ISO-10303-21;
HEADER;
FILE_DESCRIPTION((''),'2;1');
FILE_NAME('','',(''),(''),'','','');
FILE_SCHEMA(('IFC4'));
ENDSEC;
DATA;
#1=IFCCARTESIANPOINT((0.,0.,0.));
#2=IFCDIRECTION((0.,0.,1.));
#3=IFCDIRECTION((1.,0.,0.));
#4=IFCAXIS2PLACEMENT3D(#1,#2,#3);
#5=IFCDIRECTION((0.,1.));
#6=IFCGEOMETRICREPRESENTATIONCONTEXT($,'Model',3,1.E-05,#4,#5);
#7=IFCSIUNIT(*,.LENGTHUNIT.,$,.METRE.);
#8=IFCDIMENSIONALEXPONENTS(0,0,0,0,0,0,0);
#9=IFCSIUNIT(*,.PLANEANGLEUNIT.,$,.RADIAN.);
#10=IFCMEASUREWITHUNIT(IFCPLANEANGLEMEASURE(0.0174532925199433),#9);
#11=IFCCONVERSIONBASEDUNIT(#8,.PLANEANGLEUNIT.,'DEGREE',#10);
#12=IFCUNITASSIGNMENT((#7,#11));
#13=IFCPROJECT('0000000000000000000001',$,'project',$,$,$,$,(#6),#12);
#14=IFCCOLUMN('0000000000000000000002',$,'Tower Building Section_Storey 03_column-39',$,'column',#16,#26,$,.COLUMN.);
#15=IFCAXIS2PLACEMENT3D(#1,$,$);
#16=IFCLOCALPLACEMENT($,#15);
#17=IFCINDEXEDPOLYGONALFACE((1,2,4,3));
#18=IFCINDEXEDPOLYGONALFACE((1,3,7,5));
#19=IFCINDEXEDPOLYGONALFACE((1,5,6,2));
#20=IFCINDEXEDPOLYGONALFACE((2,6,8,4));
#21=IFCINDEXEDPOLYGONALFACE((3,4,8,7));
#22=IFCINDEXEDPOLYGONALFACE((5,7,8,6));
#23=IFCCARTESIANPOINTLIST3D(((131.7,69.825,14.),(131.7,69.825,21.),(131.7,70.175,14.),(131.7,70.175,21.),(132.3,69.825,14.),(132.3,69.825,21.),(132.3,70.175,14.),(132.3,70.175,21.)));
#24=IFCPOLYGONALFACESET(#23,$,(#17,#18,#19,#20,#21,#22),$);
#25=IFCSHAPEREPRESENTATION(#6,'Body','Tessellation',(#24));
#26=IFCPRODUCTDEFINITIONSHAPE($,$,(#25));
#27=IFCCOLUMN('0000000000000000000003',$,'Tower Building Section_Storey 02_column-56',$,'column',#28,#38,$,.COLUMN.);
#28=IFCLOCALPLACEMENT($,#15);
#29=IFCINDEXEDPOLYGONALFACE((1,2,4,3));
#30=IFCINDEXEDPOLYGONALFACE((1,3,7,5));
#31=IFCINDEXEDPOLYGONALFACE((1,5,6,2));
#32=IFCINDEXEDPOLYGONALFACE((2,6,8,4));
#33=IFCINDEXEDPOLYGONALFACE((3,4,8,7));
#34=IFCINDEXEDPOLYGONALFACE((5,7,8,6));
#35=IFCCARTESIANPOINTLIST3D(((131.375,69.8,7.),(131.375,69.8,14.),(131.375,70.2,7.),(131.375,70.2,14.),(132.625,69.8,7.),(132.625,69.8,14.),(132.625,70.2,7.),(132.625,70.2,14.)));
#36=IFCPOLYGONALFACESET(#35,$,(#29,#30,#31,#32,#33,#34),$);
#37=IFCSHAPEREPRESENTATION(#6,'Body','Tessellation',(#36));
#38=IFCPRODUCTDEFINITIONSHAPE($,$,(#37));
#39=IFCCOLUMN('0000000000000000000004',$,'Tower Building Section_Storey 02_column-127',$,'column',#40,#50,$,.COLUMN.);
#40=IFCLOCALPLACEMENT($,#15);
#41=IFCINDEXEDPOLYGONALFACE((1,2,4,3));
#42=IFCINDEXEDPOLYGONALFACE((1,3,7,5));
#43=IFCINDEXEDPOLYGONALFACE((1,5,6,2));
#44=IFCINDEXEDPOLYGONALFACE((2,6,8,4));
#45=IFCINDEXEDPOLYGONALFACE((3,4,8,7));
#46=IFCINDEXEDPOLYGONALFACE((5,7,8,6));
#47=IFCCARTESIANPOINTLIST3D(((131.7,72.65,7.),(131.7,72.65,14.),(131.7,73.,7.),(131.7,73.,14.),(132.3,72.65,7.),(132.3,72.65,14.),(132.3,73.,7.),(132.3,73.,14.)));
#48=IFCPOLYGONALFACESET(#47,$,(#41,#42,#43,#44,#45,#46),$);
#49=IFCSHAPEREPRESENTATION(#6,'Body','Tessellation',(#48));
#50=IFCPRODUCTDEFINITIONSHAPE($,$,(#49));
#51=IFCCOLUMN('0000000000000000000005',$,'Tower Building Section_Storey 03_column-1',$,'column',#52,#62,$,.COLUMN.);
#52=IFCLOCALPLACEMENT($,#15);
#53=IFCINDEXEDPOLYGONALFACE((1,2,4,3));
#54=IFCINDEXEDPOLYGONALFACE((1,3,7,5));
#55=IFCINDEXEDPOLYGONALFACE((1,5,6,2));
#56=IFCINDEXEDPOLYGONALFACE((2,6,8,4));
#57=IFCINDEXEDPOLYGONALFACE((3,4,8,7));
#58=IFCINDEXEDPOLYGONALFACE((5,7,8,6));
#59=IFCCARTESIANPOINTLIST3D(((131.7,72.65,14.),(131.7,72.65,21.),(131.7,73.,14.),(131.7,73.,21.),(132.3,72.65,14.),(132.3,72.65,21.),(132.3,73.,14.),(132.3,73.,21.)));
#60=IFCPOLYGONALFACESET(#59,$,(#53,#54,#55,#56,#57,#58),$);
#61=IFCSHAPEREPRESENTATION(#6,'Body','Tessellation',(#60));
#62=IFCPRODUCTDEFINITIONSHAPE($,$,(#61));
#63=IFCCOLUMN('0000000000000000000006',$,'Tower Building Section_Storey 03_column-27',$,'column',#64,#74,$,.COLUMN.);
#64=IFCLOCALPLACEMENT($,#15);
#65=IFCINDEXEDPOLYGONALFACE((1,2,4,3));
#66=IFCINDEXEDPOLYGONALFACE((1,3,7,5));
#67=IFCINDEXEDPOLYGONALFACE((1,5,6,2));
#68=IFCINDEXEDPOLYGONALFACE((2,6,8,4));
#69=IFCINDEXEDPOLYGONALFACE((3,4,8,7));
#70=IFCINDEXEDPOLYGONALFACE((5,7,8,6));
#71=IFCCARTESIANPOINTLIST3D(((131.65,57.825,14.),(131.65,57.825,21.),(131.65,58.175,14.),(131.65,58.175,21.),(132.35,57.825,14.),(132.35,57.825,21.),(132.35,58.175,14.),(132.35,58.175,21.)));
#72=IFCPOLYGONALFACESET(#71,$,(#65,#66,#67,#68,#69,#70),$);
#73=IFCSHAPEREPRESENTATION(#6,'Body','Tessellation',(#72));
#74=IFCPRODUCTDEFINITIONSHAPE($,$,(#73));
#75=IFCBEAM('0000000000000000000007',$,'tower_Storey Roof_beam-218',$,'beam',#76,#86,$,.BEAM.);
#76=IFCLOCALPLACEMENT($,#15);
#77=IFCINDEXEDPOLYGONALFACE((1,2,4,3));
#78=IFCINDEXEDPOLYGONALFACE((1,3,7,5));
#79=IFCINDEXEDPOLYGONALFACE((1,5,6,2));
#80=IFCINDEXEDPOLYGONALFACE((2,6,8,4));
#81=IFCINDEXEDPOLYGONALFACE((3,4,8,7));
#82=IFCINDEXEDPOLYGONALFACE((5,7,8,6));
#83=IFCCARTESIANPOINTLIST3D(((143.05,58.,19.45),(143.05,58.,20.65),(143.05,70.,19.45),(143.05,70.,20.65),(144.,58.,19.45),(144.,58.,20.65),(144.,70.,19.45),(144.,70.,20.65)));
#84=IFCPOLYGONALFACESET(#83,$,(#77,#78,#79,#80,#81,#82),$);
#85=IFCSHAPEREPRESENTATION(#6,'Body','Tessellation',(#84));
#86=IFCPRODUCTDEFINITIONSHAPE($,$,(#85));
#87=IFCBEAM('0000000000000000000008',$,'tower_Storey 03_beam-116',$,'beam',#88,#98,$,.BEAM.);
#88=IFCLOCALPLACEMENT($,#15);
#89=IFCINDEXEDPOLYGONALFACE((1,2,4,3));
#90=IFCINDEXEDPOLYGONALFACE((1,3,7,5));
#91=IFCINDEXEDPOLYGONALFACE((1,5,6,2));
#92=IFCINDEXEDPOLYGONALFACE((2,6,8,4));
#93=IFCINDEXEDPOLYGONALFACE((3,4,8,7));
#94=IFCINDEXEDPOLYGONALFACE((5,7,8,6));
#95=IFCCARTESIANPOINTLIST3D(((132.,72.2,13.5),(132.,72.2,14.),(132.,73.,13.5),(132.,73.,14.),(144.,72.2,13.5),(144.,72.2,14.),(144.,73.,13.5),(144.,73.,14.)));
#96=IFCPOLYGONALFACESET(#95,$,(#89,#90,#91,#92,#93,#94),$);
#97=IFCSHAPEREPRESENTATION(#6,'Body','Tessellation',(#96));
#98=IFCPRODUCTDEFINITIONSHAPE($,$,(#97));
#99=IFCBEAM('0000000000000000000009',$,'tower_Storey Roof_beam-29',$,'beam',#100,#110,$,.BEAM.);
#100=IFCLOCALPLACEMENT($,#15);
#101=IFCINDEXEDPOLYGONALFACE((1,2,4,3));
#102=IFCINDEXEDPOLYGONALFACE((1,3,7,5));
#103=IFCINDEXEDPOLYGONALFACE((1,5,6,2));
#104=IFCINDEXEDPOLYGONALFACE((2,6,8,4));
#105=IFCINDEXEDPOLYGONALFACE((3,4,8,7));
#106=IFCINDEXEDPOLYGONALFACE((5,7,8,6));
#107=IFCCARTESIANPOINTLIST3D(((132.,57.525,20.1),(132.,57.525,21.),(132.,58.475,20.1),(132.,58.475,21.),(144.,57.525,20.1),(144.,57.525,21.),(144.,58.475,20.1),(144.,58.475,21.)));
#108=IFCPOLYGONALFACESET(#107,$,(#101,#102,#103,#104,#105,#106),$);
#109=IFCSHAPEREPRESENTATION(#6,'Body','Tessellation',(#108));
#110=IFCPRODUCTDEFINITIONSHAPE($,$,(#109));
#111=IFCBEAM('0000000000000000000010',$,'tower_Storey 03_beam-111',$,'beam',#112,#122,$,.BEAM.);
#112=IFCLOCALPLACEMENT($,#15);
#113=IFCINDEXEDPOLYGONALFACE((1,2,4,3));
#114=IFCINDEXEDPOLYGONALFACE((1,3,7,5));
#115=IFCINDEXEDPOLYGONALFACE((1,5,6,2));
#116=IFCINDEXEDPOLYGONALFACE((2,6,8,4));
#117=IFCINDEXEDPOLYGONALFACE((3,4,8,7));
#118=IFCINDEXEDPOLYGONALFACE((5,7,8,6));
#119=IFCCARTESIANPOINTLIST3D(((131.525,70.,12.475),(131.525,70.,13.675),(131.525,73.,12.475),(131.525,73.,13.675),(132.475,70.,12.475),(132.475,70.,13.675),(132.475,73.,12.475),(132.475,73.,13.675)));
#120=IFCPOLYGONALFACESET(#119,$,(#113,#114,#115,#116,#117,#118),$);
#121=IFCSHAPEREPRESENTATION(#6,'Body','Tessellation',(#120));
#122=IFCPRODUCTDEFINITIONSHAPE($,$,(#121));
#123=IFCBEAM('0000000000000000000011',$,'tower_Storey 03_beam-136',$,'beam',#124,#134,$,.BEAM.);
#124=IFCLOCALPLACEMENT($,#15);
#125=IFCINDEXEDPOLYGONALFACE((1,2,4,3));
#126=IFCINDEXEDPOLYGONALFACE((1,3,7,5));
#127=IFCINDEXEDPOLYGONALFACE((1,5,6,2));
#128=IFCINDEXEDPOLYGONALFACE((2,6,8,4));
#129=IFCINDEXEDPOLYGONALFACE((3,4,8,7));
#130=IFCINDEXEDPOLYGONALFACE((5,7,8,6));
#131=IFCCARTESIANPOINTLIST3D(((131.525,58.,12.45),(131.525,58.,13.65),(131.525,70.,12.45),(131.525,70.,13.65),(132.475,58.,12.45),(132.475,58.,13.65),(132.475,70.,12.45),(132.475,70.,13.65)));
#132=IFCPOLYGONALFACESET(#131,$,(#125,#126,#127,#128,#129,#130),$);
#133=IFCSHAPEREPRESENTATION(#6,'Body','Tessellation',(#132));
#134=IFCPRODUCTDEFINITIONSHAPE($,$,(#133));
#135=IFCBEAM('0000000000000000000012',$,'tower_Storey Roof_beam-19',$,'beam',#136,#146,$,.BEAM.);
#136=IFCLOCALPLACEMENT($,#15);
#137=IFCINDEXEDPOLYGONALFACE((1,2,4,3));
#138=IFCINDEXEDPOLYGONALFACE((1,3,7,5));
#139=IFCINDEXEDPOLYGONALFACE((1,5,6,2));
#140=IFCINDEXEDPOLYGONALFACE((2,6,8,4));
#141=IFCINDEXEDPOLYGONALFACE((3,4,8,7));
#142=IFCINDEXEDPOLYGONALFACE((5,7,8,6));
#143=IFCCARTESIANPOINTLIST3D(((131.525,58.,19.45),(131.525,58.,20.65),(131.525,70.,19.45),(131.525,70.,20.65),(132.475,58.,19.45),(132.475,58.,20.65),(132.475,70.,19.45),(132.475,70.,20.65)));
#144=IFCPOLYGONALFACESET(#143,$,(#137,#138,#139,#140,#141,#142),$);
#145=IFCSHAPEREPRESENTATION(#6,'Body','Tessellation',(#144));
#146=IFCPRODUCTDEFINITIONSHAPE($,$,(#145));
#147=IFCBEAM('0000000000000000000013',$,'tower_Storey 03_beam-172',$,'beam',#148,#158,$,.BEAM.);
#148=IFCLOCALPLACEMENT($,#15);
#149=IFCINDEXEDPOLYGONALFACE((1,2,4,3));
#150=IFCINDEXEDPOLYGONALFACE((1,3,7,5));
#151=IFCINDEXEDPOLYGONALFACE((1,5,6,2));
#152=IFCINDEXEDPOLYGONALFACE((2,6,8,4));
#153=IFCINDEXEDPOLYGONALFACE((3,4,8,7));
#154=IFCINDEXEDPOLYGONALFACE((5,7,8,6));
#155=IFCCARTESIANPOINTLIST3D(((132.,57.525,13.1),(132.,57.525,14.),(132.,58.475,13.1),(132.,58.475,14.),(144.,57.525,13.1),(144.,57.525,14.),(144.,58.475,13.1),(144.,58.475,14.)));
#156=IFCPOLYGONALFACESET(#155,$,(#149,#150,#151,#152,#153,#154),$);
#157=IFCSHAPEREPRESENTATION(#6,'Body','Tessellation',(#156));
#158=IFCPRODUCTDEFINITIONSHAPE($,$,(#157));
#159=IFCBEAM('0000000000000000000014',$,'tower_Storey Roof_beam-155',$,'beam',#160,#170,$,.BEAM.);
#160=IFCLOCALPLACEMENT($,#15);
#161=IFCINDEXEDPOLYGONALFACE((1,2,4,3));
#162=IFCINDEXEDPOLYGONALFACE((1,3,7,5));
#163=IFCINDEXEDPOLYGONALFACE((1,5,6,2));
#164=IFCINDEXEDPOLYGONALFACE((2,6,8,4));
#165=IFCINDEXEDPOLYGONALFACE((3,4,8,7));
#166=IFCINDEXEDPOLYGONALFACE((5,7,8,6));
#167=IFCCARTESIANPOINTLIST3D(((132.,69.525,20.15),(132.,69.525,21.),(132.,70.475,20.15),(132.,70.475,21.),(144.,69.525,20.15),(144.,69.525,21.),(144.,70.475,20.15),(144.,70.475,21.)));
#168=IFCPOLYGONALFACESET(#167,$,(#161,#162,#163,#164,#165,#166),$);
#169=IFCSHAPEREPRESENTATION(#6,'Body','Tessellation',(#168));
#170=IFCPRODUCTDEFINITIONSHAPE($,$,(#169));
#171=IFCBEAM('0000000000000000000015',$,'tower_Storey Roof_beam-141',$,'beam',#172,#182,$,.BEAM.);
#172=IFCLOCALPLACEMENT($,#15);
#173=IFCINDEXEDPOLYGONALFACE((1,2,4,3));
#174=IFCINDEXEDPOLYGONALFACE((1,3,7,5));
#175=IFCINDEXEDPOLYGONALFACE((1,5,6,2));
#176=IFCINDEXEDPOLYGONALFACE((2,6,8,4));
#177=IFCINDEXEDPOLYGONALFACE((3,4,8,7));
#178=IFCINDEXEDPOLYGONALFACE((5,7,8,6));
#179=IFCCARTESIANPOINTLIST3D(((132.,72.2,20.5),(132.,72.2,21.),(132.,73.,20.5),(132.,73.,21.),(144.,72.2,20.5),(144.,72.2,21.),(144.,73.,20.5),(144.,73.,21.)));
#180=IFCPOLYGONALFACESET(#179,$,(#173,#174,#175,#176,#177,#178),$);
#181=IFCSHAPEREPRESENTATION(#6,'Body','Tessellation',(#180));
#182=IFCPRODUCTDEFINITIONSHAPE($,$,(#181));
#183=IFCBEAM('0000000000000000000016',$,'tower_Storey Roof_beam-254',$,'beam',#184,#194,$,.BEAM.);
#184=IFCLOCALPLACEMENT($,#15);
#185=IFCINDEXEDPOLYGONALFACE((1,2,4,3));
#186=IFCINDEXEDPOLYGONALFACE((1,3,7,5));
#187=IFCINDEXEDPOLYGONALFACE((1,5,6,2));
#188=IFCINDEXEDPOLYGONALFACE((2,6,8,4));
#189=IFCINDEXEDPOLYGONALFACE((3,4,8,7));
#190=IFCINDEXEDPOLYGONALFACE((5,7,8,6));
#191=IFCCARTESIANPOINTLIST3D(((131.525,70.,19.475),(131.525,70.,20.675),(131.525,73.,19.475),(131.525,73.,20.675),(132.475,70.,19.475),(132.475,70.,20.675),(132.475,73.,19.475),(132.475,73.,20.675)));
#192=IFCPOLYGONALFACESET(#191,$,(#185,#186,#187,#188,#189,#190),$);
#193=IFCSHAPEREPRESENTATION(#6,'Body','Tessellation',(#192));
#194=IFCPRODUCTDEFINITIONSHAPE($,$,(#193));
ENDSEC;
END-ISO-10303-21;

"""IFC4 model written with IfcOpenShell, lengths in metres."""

from ifc_helpers import new_model, entity, si_unit, converted_unit, direction, frame, origin_with_axes, place, context, project, polyline, outline, extrude, element, save


model = new_model("IFC4")

# Units and contexts
model_context = context("Model", 3, precision=1e-05, world=origin_with_axes(), true_north=direction((0.0, 1.0)))
ifc_project = project(units=[si_unit("LENGTHUNIT", "METRE"), converted_unit("PLANEANGLEUNIT", "DEGREE", entity("IfcPlaneAngleMeasure", 0.0174532925199433), si_unit("PLANEANGLEUNIT", "RADIAN"), dimensions=[0, 0, 0, 0, 0, 0, 0])], contexts=[model_context])

# Columns
placement_1 = place(None, origin_with_axes())
placement_2 = place(placement_1, frame((0.0, 0.0, 14.0), z_axis=(0.0, 0.0, 1.0), x_axis=(1.0, 0.0, 0.0)))
column_1_placement = place(placement_2, frame((132.0, 70.0, 0.0), z_axis=(0.0, 0.0, 1.0), x_axis=(1.0, 0.0, 0.0)))
element("IfcColumn", 1, at=column_1_placement, Name="Tower Building Section_Storey 03_column-39", ObjectType="column", PredefinedType="COLUMN", context=model_context, body=[
    extrude(outline(polyline([(-0.3, -0.175, 0.0), (0.3, -0.175, 0.0), (0.3, 0.175, 0.0), (-0.3, 0.175, 0.0), (-0.3, -0.175, 0.0)])), origin_with_axes(), (0.0, 0.0, 1.0), 7.0),
])
placement_3 = place(placement_1, frame((0.0, 0.0, 7.0), z_axis=(0.0, 0.0, 1.0), x_axis=(1.0, 0.0, 0.0)))
column_2_placement = place(placement_3, frame((132.0, 70.0, 0.0), z_axis=(0.0, 0.0, 1.0), x_axis=(1.0, 0.0, 0.0)))
element("IfcColumn", 2, at=column_2_placement, Name="Tower Building Section_Storey 02_column-56", ObjectType="column", PredefinedType="COLUMN", context=model_context, body=[
    extrude(outline(polyline([(-0.625, -0.2, 0.0), (0.625, -0.2, 0.0), (0.625, 0.2, 0.0), (-0.625, 0.2, 0.0), (-0.625, -0.2, 0.0)])), origin_with_axes(), (0.0, 0.0, 1.0), 7.0),
])
column_3_placement = place(placement_3, frame((132.0, 72.825, 0.0), z_axis=(0.0, 0.0, 1.0), x_axis=(1.0, 0.0, 0.0)))
element("IfcColumn", 3, at=column_3_placement, Name="Tower Building Section_Storey 02_column-127", ObjectType="column", PredefinedType="COLUMN", context=model_context, body=[
    extrude(outline(polyline([(-0.3, -0.175, 0.0), (0.3, -0.175, 0.0), (0.3, 0.175, 0.0), (-0.3, 0.175, 0.0), (-0.3, -0.175, 0.0)])), origin_with_axes(), (0.0, 0.0, 1.0), 7.0),
])
column_4_placement = place(placement_2, frame((132.0, 72.825, 0.0), z_axis=(0.0, 0.0, 1.0), x_axis=(1.0, 0.0, 0.0)))
element("IfcColumn", 4, at=column_4_placement, Name="Tower Building Section_Storey 03_column-1", ObjectType="column", PredefinedType="COLUMN", context=model_context, body=[
    extrude(outline(polyline([(-0.3, -0.175, 0.0), (0.3, -0.175, 0.0), (0.3, 0.175, 0.0), (-0.3, 0.175, 0.0), (-0.3, -0.175, 0.0)])), origin_with_axes(), (0.0, 0.0, 1.0), 7.0),
])
column_5_placement = place(placement_2, frame((132.0, 58.0, 0.0), z_axis=(0.0, 0.0, 1.0), x_axis=(1.0, 0.0, 0.0)))
element("IfcColumn", 5, at=column_5_placement, Name="Tower Building Section_Storey 03_column-27", ObjectType="column", PredefinedType="COLUMN", context=model_context, body=[
    extrude(outline(polyline([(-0.35, -0.175, 0.0), (0.35, -0.175, 0.0), (0.35, 0.175, 0.0), (-0.35, 0.175, 0.0), (-0.35, -0.175, 0.0)])), origin_with_axes(), (0.0, 0.0, 1.0), 7.0),
])

# Beams
placement_4 = place(placement_1, frame((0.0, 0.0, 21.0), z_axis=(0.0, 0.0, 1.0), x_axis=(1.0, 0.0, 0.0)))
beam_1_placement = place(placement_4, frame((143.525, 58.0, -0.95), z_axis=(0.0, 1.0, 0.0), x_axis=(-1.0, 0.0, 0.0)))
element("IfcBeam", 6, at=beam_1_placement, Name="tower_Storey Roof_beam-218", ObjectType="beam", PredefinedType="BEAM", context=model_context, body=[
    extrude(outline(polyline([(0.475, 0.6, 0.0), (-0.475, 0.6, 0.0), (-0.475, -0.6, 0.0), (0.475, -0.6, 0.0), (0.475, 0.6, 0.0)])), origin_with_axes(), (0.0, 0.0, 1.0), 12.0),
])
beam_2_placement = place(placement_2, frame((132.0, 72.6, -0.25), z_axis=(1.0, 0.0, 0.0), x_axis=(0.0, 1.0, 0.0)))
element("IfcBeam", 7, at=beam_2_placement, Name="tower_Storey 03_beam-116", ObjectType="beam", PredefinedType="BEAM", context=model_context, body=[
    extrude(outline(polyline([(0.4, 0.25, 0.0), (-0.4, 0.25, 0.0), (-0.4, -0.25, 0.0), (0.4, -0.25, 0.0), (0.4, 0.25, 0.0)])), origin_with_axes(), (0.0, 0.0, 1.0), 12.0),
])
beam_3_placement = place(placement_4, frame((132.0, 58.0, -0.45), z_axis=(1.0, 0.0, 0.0), x_axis=(0.0, 1.0, 0.0)))
element("IfcBeam", 8, at=beam_3_placement, Name="tower_Storey Roof_beam-29", ObjectType="beam", PredefinedType="BEAM", context=model_context, body=[
    extrude(outline(polyline([(0.475, 0.45, 0.0), (-0.475, 0.45, 0.0), (-0.475, -0.45, 0.0), (0.475, -0.45, 0.0), (0.475, 0.45, 0.0)])), origin_with_axes(), (0.0, 0.0, 1.0), 12.0),
])
beam_4_placement = place(placement_2, frame((132.0, 70.0, -0.925), z_axis=(0.0, 1.0, 0.0), x_axis=(-1.0, 0.0, 0.0)))
element("IfcBeam", 9, at=beam_4_placement, Name="tower_Storey 03_beam-111", ObjectType="beam", PredefinedType="BEAM", context=model_context, body=[
    extrude(outline(polyline([(0.475, 0.6, 0.0), (-0.475, 0.6, 0.0), (-0.475, -0.6, 0.0), (0.475, -0.6, 0.0), (0.475, 0.6, 0.0)])), origin_with_axes(), (0.0, 0.0, 1.0), 3.0),
])
beam_5_placement = place(placement_2, frame((132.0, 58.0, -0.95), z_axis=(0.0, 1.0, 0.0), x_axis=(-1.0, 0.0, 0.0)))
element("IfcBeam", 10, at=beam_5_placement, Name="tower_Storey 03_beam-136", ObjectType="beam", PredefinedType="BEAM", context=model_context, body=[
    extrude(outline(polyline([(0.475, 0.6, 0.0), (-0.475, 0.6, 0.0), (-0.475, -0.6, 0.0), (0.475, -0.6, 0.0), (0.475, 0.6, 0.0)])), origin_with_axes(), (0.0, 0.0, 1.0), 12.0),
])
beam_6_placement = place(placement_4, frame((132.0, 58.0, -0.95), z_axis=(0.0, 1.0, 0.0), x_axis=(-1.0, 0.0, 0.0)))
element("IfcBeam", 11, at=beam_6_placement, Name="tower_Storey Roof_beam-19", ObjectType="beam", PredefinedType="BEAM", context=model_context, body=[
    extrude(outline(polyline([(0.475, 0.6, 0.0), (-0.475, 0.6, 0.0), (-0.475, -0.6, 0.0), (0.475, -0.6, 0.0), (0.475, 0.6, 0.0)])), origin_with_axes(), (0.0, 0.0, 1.0), 12.0),
])
beam_7_placement = place(placement_2, frame((132.0, 58.0, -0.45), z_axis=(1.0, 0.0, 0.0), x_axis=(0.0, 1.0, 0.0)))
element("IfcBeam", 12, at=beam_7_placement, Name="tower_Storey 03_beam-172", ObjectType="beam", PredefinedType="BEAM", context=model_context, body=[
    extrude(outline(polyline([(0.475, 0.45, 0.0), (-0.475, 0.45, 0.0), (-0.475, -0.45, 0.0), (0.475, -0.45, 0.0), (0.475, 0.45, 0.0)])), origin_with_axes(), (0.0, 0.0, 1.0), 12.0),
])
beam_8_placement = place(placement_4, frame((132.0, 70.0, -0.425), z_axis=(1.0, 0.0, 0.0), x_axis=(0.0, 1.0, 0.0)))
element("IfcBeam", 13, at=beam_8_placement, Name="tower_Storey Roof_beam-155", ObjectType="beam", PredefinedType="BEAM", context=model_context, body=[
    extrude(outline(polyline([(0.475, 0.425, 0.0), (-0.475, 0.425, 0.0), (-0.475, -0.425, 0.0), (0.475, -0.425, 0.0), (0.475, 0.425, 0.0)])), origin_with_axes(), (0.0, 0.0, 1.0), 12.0),
])
beam_9_placement = place(placement_4, frame((132.0, 72.6, -0.25), z_axis=(1.0, 0.0, 0.0), x_axis=(0.0, 1.0, 0.0)))
element("IfcBeam", 14, at=beam_9_placement, Name="tower_Storey Roof_beam-141", ObjectType="beam", PredefinedType="BEAM", context=model_context, body=[
    extrude(outline(polyline([(0.4, 0.25, 0.0), (-0.4, 0.25, 0.0), (-0.4, -0.25, 0.0), (0.4, -0.25, 0.0), (0.4, 0.25, 0.0)])), origin_with_axes(), (0.0, 0.0, 1.0), 12.0),
])
beam_10_placement = place(placement_4, frame((132.0, 70.0, -0.925), z_axis=(0.0, 1.0, 0.0), x_axis=(-1.0, 0.0, 0.0)))
element("IfcBeam", 15, at=beam_10_placement, Name="tower_Storey Roof_beam-254", ObjectType="beam", PredefinedType="BEAM", context=model_context, body=[
    extrude(outline(polyline([(0.475, 0.6, 0.0), (-0.475, 0.6, 0.0), (-0.475, -0.6, 0.0), (0.475, -0.6, 0.0), (0.475, 0.6, 0.0)])), origin_with_axes(), (0.0, 0.0, 1.0), 3.0),
])

save(model, "model.ifc")
